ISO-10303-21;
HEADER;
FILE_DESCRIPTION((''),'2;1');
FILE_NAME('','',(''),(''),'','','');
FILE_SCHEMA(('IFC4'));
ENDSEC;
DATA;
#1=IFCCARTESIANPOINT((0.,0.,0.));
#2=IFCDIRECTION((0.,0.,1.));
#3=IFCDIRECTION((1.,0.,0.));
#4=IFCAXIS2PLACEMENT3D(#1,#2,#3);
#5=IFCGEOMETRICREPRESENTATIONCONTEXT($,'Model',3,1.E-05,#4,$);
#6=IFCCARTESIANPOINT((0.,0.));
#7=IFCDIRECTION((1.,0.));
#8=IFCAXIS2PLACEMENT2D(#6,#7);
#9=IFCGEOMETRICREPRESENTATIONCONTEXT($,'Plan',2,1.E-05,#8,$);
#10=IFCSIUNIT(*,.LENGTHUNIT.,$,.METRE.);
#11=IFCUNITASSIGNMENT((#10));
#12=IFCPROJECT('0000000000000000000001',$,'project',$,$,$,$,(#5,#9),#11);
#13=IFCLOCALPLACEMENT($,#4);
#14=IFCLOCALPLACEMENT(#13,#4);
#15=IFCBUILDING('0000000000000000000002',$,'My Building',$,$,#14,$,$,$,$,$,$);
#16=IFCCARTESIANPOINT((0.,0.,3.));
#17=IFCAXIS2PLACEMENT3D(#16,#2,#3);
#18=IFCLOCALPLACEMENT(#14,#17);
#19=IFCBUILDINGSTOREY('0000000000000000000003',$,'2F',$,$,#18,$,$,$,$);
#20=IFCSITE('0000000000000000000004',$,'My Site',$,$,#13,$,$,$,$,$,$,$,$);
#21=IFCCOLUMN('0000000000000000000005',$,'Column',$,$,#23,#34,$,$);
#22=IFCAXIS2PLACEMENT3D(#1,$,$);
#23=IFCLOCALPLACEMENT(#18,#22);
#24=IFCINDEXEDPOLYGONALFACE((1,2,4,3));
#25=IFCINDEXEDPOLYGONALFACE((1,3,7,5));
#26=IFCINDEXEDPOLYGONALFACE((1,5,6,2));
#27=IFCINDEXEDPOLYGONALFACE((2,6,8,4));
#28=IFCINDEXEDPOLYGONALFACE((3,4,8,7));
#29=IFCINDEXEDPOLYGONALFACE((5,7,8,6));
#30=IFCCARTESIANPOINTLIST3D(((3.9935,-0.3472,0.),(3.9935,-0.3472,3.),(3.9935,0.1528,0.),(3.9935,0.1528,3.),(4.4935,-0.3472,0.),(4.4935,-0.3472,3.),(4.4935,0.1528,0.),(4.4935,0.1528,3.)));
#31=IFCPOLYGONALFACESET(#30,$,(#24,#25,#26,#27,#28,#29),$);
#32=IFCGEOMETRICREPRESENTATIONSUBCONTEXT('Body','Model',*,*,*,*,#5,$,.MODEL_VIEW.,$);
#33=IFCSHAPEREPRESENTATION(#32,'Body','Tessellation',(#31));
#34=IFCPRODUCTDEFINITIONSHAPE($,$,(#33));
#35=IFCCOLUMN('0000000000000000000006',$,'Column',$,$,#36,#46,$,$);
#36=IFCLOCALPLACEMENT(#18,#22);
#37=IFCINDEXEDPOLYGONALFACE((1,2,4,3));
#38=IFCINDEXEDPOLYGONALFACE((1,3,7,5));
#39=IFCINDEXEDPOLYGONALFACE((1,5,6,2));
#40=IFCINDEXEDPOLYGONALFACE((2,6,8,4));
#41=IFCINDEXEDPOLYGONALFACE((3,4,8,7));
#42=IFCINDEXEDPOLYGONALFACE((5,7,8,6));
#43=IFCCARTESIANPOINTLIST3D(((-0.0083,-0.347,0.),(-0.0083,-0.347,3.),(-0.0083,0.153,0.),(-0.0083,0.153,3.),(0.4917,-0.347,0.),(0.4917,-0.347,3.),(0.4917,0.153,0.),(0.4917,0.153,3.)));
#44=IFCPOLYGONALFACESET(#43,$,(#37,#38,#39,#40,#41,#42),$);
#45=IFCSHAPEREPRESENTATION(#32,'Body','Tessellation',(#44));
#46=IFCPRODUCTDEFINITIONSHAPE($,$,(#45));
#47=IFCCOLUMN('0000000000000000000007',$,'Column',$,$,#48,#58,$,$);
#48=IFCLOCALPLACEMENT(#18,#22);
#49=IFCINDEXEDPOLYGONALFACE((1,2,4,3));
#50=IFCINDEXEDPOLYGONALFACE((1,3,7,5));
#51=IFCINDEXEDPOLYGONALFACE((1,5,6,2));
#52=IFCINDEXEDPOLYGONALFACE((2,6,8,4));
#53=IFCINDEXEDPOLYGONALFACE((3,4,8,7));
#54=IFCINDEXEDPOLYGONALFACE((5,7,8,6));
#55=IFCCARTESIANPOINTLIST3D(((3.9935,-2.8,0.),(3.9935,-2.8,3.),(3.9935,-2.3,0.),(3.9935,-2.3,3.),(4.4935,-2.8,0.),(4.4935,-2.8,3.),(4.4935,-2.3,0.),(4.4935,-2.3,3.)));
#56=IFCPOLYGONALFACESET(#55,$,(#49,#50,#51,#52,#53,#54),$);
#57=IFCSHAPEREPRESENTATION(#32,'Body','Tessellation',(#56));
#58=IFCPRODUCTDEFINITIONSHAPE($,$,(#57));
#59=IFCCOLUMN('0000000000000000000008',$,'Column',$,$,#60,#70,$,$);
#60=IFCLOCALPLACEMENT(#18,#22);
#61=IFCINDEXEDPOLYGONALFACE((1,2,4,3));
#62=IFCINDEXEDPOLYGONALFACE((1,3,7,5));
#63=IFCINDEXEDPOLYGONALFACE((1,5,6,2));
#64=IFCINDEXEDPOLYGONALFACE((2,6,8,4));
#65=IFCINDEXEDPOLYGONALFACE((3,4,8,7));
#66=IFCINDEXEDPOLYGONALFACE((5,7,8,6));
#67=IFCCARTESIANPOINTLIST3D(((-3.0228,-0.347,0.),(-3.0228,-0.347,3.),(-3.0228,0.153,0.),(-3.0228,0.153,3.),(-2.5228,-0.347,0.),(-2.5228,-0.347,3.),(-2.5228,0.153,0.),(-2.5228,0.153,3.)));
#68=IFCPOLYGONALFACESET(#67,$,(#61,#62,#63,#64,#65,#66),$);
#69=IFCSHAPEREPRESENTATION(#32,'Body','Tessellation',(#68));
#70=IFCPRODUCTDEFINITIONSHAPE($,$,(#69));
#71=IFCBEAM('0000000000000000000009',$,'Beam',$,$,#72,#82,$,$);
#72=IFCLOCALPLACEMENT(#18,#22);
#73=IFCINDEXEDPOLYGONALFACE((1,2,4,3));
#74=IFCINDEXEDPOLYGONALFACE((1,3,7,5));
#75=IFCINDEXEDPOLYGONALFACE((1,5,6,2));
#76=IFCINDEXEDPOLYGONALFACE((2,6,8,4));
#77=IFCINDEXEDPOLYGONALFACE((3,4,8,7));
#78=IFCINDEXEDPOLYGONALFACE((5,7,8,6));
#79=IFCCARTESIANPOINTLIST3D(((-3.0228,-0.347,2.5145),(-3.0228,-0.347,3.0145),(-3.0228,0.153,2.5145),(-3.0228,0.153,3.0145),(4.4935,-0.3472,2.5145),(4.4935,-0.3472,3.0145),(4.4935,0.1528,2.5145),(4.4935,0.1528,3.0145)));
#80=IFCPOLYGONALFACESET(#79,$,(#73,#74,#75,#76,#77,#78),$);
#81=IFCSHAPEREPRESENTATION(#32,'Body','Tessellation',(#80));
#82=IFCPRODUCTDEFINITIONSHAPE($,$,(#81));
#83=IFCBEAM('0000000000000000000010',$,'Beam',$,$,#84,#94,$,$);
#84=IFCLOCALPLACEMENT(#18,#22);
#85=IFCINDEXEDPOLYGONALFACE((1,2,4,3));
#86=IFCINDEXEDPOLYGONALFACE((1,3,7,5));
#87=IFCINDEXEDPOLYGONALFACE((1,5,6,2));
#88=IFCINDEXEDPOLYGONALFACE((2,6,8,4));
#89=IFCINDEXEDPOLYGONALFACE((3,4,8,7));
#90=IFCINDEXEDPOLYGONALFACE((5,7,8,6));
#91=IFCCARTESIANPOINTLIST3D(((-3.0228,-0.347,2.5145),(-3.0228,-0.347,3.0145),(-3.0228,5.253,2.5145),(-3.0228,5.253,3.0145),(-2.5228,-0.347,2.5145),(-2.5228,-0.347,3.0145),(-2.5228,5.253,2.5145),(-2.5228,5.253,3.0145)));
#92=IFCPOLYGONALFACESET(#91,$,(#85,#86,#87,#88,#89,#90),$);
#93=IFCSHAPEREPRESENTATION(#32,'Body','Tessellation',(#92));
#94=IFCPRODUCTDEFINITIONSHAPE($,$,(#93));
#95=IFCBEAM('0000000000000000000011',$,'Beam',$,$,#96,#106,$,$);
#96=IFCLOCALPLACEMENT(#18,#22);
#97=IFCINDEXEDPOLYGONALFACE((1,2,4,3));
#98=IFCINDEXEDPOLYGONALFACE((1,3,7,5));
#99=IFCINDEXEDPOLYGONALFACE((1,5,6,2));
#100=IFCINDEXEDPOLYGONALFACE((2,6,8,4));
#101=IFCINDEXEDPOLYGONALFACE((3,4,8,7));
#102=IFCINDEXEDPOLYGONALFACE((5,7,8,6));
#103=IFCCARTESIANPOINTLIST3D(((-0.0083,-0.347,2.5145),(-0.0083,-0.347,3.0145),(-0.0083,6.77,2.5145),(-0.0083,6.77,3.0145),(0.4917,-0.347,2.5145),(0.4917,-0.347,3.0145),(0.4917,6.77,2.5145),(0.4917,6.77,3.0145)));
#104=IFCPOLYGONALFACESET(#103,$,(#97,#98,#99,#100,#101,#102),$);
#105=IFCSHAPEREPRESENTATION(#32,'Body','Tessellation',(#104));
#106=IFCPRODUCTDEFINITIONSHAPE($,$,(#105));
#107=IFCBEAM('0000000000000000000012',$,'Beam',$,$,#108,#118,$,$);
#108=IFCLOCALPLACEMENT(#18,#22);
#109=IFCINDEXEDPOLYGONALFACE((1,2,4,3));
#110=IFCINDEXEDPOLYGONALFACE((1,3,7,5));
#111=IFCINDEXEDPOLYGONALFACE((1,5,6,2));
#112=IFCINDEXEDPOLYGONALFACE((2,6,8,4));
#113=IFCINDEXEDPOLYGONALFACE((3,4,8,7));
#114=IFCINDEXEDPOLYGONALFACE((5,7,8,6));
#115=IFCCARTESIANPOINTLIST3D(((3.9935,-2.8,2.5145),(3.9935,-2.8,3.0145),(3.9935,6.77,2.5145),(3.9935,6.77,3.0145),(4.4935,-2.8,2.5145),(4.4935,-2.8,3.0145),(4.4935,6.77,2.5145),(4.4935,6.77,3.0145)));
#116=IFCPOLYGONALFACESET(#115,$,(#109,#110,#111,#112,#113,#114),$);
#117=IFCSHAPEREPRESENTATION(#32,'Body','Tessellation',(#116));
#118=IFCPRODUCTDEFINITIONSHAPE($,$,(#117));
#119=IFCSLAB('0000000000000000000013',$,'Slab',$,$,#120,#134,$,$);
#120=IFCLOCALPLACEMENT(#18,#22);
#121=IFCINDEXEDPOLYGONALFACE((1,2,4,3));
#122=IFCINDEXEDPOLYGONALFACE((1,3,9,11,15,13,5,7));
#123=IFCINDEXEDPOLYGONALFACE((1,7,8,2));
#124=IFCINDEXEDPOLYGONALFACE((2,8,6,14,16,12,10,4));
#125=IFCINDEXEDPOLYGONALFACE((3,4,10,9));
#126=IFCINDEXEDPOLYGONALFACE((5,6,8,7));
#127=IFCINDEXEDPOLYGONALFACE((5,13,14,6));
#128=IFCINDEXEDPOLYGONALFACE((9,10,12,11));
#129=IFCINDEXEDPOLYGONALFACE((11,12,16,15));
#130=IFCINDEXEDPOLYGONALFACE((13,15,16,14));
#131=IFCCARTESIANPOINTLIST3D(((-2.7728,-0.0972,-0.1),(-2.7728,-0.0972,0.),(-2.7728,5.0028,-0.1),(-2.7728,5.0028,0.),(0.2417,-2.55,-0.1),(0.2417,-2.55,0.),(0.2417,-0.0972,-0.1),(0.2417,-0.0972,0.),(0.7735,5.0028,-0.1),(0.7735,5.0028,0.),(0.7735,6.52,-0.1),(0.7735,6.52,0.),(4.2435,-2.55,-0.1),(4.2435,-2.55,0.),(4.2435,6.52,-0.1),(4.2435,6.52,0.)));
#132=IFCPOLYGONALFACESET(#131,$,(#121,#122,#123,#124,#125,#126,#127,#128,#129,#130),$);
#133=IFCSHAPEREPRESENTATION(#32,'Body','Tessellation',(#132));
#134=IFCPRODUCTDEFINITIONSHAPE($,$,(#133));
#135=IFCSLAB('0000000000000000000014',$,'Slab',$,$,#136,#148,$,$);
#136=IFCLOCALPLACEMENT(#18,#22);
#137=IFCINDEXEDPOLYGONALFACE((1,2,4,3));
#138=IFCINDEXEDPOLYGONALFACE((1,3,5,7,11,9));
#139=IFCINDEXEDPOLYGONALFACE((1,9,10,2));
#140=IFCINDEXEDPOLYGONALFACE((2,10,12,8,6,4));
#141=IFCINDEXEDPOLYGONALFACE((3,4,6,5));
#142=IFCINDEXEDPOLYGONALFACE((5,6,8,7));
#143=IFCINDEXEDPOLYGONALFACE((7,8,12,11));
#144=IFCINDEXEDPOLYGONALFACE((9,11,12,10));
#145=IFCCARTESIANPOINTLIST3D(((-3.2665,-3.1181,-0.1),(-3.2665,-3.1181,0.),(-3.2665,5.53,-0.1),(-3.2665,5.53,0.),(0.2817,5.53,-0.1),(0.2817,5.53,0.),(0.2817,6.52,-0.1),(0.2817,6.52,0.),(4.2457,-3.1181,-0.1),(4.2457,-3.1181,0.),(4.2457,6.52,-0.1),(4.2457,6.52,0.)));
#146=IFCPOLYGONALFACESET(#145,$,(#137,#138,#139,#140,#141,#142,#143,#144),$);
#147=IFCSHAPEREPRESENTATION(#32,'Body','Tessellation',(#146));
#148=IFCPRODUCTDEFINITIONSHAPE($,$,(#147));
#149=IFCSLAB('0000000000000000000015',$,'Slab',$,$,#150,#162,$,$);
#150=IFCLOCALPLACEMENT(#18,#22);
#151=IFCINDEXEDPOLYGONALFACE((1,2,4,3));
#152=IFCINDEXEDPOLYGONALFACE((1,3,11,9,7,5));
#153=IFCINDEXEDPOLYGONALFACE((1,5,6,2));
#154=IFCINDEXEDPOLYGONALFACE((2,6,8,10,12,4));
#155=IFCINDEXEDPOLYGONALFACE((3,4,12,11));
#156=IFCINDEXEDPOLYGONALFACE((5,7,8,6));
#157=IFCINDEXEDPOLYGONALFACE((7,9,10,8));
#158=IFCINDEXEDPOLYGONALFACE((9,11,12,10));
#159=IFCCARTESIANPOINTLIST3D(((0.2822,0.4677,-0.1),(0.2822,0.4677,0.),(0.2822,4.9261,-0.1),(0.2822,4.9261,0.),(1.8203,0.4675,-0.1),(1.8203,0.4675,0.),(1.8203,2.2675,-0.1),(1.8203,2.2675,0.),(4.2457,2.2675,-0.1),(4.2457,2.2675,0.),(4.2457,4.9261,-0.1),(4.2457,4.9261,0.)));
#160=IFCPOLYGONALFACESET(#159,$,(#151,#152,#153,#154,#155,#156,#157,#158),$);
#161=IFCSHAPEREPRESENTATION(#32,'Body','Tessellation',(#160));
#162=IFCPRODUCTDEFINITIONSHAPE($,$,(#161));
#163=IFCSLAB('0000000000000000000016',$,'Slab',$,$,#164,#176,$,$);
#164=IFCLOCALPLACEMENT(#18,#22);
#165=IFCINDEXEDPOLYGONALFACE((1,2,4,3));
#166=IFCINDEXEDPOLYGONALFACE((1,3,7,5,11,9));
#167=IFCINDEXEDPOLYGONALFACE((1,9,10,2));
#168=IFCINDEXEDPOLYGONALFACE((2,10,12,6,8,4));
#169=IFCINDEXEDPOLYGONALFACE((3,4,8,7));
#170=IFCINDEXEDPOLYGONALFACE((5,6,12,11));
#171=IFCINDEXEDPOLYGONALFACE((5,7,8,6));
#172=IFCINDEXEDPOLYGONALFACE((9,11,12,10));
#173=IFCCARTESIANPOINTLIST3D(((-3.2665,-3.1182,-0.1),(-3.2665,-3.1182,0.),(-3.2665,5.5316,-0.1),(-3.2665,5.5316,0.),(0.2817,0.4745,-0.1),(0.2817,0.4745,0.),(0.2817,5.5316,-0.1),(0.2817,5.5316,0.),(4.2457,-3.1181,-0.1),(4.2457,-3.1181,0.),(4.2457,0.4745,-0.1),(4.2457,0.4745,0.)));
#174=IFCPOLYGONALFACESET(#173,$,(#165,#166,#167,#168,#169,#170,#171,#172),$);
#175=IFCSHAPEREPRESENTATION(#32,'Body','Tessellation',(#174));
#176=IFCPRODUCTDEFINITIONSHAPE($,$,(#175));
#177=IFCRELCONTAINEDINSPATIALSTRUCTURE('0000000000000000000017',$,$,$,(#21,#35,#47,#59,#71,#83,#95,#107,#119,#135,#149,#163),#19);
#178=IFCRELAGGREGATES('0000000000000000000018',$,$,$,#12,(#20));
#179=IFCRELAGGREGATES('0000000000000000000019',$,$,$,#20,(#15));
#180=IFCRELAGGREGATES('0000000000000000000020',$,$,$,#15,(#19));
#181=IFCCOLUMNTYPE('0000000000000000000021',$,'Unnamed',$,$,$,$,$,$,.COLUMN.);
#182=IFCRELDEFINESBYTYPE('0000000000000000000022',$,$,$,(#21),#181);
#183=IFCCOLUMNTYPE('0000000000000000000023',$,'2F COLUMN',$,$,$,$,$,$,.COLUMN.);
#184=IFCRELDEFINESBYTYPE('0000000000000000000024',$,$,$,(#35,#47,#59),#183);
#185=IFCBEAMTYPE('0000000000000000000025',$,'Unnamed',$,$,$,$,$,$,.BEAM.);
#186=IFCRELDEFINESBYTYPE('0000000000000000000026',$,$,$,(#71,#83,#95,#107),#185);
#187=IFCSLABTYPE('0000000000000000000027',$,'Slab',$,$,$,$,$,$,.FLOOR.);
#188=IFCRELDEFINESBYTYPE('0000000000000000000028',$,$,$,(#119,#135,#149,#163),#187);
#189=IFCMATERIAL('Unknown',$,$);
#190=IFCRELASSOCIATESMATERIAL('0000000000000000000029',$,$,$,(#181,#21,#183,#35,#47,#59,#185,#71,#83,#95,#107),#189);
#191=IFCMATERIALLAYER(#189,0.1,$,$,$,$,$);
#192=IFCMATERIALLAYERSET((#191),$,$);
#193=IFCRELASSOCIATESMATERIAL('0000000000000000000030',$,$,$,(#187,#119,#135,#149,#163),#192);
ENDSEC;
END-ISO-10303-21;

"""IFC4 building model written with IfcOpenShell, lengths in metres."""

from ifc_helpers import new_model, si_unit, frame, origin_with_axes, origin_2d_with_axis, place, context, subcontext, project, spatial, indexed_curve, rectangle, outline, extrude, material, layer, layer_set, layer_usage, material_profile, profile_set, profile_usage, type_object, element, save


model = new_model("IFC4")

# Units and contexts
model_context = context("Model", 3, precision=1e-05, world=origin_with_axes())
plan_context = context("Plan", 2, precision=1e-05, world=origin_2d_with_axis())
body_context_1 = subcontext(model_context, "Body", "Model", "MODEL_VIEW")
ifc_project = project(units=[si_unit("LENGTHUNIT", "METRE")], contexts=[model_context, plan_context])

# Site, building, storey
site_placement = place(None, origin_with_axes())
site = spatial("IfcSite", under=ifc_project, at=site_placement, Name="My Site")
building_placement = place(site_placement, origin_with_axes())
building = spatial("IfcBuilding", under=site, at=building_placement, Name="My Building")
storey_placement = place(building_placement, frame((0.0, 0.0, 3.0), z_axis=(0.0, 0.0, 1.0), x_axis=(1.0, 0.0, 0.0)))
storey = spatial("IfcBuildingStorey", under=building, at=storey_placement, Name="2F")

# Columns
ifc_material = material(Name="Unknown")
ifc_material_profile_1 = material_profile(ifc_material, rectangle(XDim=0.5, YDim=0.5))
ifc_profile_set_1 = profile_set([ifc_material_profile_1])
ifc_profile_usage_1 = profile_usage(ifc_profile_set_1, cardinal=7)
column_type_1 = type_object("IfcColumnType", Name="Unnamed", PredefinedType="COLUMN", material=ifc_profile_set_1)
column_1_placement = place(storey_placement, frame((4.4935, 0.1528, 0.0), z_axis=(0.0, 0.0, 1.0), x_axis=(1.0, 0.0, 0.0)))
element("IfcColumn", 1, at=column_1_placement, inside=storey, type_object=column_type_1, material=ifc_profile_usage_1, Name="Column", context=body_context_1, shape_type="SweptSolid", body=[
    extrude(rectangle(XDim=0.5, YDim=0.5), frame((-0.25, -0.25, 0.0), z_axis=(0.0, 0.0, 1.0), x_axis=(1.0, 0.0, 0.0)), (0.0, 0.0, 1.0), 3.0),
])
ifc_material_profile_2 = material_profile(ifc_material, rectangle(XDim=0.5, YDim=0.5))
ifc_profile_set_2 = profile_set([ifc_material_profile_2])
ifc_profile_usage_2 = profile_usage(ifc_profile_set_2, cardinal=7)
column_type_2 = type_object("IfcColumnType", Name="2F COLUMN", PredefinedType="COLUMN", material=ifc_profile_set_2)
column_2_placement = place(storey_placement, frame((0.4917, 0.153, 0.0), z_axis=(0.0, 0.0, 1.0), x_axis=(1.0, 0.0, 0.0)))
element("IfcColumn", 2, at=column_2_placement, inside=storey, type_object=column_type_2, material=ifc_profile_usage_2, Name="Column", context=body_context_1, shape_type="SweptSolid", body=[
    extrude(rectangle(XDim=0.5, YDim=0.5), frame((-0.25, -0.25, 0.0), z_axis=(0.0, 0.0, 1.0), x_axis=(1.0, 0.0, 0.0)), (0.0, 0.0, 1.0), 3.0),
])
ifc_profile_usage_3 = profile_usage(ifc_profile_set_2, cardinal=7)
column_3_placement = place(storey_placement, frame((4.4935, -2.3, 0.0), z_axis=(0.0, 0.0, 1.0), x_axis=(1.0, 0.0, 0.0)))
element("IfcColumn", 3, at=column_3_placement, inside=storey, type_object=column_type_2, material=ifc_profile_usage_3, Name="Column", context=body_context_1, shape_type="SweptSolid", body=[
    extrude(rectangle(XDim=0.5, YDim=0.5), frame((-0.25, -0.25, 0.0), z_axis=(0.0, 0.0, 1.0), x_axis=(1.0, 0.0, 0.0)), (0.0, 0.0, 1.0), 3.0),
])
ifc_profile_usage_4 = profile_usage(ifc_profile_set_2, cardinal=7)
column_4_placement = place(storey_placement, frame((-2.5228, 0.153, 0.0), z_axis=(0.0, 0.0, 1.0), x_axis=(1.0, 0.0, 0.0)))
element("IfcColumn", 4, at=column_4_placement, inside=storey, type_object=column_type_2, material=ifc_profile_usage_4, Name="Column", context=body_context_1, shape_type="SweptSolid", body=[
    extrude(rectangle(XDim=0.5, YDim=0.5), frame((-0.25, -0.25, 0.0), z_axis=(0.0, 0.0, 1.0), x_axis=(1.0, 0.0, 0.0)), (0.0, 0.0, 1.0), 3.0),
])

# Beams
ifc_material_profile_3 = material_profile(ifc_material, rectangle(XDim=0.5, YDim=0.5))
ifc_profile_set_3 = profile_set([ifc_material_profile_3])
ifc_profile_usage_5 = profile_usage(ifc_profile_set_3, cardinal=7)
beam_type = type_object("IfcBeamType", Name="Unnamed", PredefinedType="BEAM", material=ifc_profile_set_3)
beam_1_placement = place(storey_placement, frame((-3.0228, 0.153, 3.0145), z_axis=(1.0, -0.000025, 0.0), x_axis=(0.000025, 1.0, 0.0)))
element("IfcBeam", 5, at=beam_1_placement, inside=storey, type_object=beam_type, material=ifc_profile_usage_5, Name="Beam", context=body_context_1, shape_type="SweptSolid", body=[
    extrude(rectangle(XDim=0.5, YDim=0.5), frame((-0.25, -0.25, 0.0), z_axis=(0.0, 0.0, 1.0), x_axis=(1.0, 0.0, 0.0)), (0.0, 0.0, 1.0), 7.5163),
])
ifc_profile_usage_6 = profile_usage(ifc_profile_set_3, cardinal=7)
beam_2_placement = place(storey_placement, frame((-3.0228, -0.347, 3.0145), z_axis=(0.0, 1.0, 0.0), x_axis=(-1.0, 0.0, 0.0)))
element("IfcBeam", 6, at=beam_2_placement, inside=storey, type_object=beam_type, material=ifc_profile_usage_6, Name="Beam", context=body_context_1, shape_type="SweptSolid", body=[
    extrude(rectangle(XDim=0.5, YDim=0.5), frame((-0.25, -0.25, 0.0), z_axis=(0.0, 0.0, 1.0), x_axis=(1.0, 0.0, 0.0)), (0.0, 0.0, 1.0), 5.6),
])
ifc_profile_usage_7 = profile_usage(ifc_profile_set_3, cardinal=7)
beam_3_placement = place(storey_placement, frame((-0.0083, -0.347, 3.0145), z_axis=(0.0, 1.0, 0.0), x_axis=(-1.0, 0.0, 0.0)))
element("IfcBeam", 7, at=beam_3_placement, inside=storey, type_object=beam_type, material=ifc_profile_usage_7, Name="Beam", context=body_context_1, shape_type="SweptSolid", body=[
    extrude(rectangle(XDim=0.5, YDim=0.5), frame((-0.25, -0.25, 0.0), z_axis=(0.0, 0.0, 1.0), x_axis=(1.0, 0.0, 0.0)), (0.0, 0.0, 1.0), 7.117),
])
ifc_profile_usage_8 = profile_usage(ifc_profile_set_3, cardinal=7)
beam_4_placement = place(storey_placement, frame((3.9935, -2.8, 3.0145), z_axis=(0.0, 1.0, 0.0), x_axis=(-1.0, 0.0, 0.0)))
element("IfcBeam", 8, at=beam_4_placement, inside=storey, type_object=beam_type, material=ifc_profile_usage_8, Name="Beam", context=body_context_1, shape_type="SweptSolid", body=[
    extrude(rectangle(XDim=0.5, YDim=0.5), frame((-0.25, -0.25, 0.0), z_axis=(0.0, 0.0, 1.0), x_axis=(1.0, 0.0, 0.0)), (0.0, 0.0, 1.0), 9.57),
])

# Slabs
ifc_layer_1 = layer(ifc_material, 0.1)
ifc_layer_set_1 = layer_set([ifc_layer_1])
ifc_layer_usage_1 = layer_usage(ifc_layer_set_1, "AXIS3", "POSITIVE", -0.1)
slab_type = type_object("IfcSlabType", Name="Slab", PredefinedType="FLOOR", material=ifc_layer_set_1)
slab_1_placement = place(storey_placement, frame((4.2435, -2.55, 0.0), z_axis=(0.0, 0.0, 1.0), x_axis=(1.0, 0.0, 0.0)))
element("IfcSlab", 9, at=slab_1_placement, inside=storey, type_object=slab_type, material=ifc_layer_usage_1, Name="Slab", context=body_context_1, shape_type="SweptSolid", body=[
    extrude(outline(indexed_curve([(0.0, 0.0), (0.0, 9.07), (-3.47, 9.07), (-3.47, 7.5528), (-7.0163, 7.5528), (-7.0163, 2.4528), (-4.0018, 2.4528), (-4.0018, 0.0), (0.0, 0.0)])), frame((0.0, 0.0, -0.1), z_axis=(0.0, 0.0, 1.0), x_axis=(1.0, 0.0, 0.0)), (0.0, 0.0, 1.0), 0.1),
])
ifc_layer_usage_2 = layer_usage(ifc_layer_set_1, "AXIS3", "POSITIVE", -0.1)
slab_2_placement = place(storey_placement, frame((4.2457, -3.1181, 0.0), z_axis=(0.0, 0.0, 1.0), x_axis=(1.0, 0.0, 0.0)))
element("IfcSlab", 10, at=slab_2_placement, inside=storey, type_object=slab_type, material=ifc_layer_usage_2, Name="Slab", context=body_context_1, shape_type="SweptSolid", body=[
    extrude(outline(indexed_curve([(0.0, 0.0), (0.0, 9.6381), (-3.964, 9.6381), (-3.964, 8.6481), (-7.5122, 8.6481), (-7.5122, 0.0), (0.0, 0.0)])), frame((0.0, 0.0, -0.1), z_axis=(0.0, 0.0, 1.0), x_axis=(1.0, 0.0, 0.0)), (0.0, 0.0, 1.0), 0.1),
])
ifc_layer_usage_3 = layer_usage(ifc_layer_set_1, "AXIS3", "POSITIVE", -0.1)
slab_3_placement = place(storey_placement, frame((1.8203, 0.4675, 0.0), z_axis=(0.0, 0.0, 1.0), x_axis=(1.0, 0.0, 0.0)))
element("IfcSlab", 11, at=slab_3_placement, inside=storey, type_object=slab_type, material=ifc_layer_usage_3, Name="Slab", context=body_context_1, shape_type="SweptSolid", body=[
    extrude(outline(indexed_curve([(0.0, 0.0), (0.0, 1.8), (2.4254, 1.8), (2.4254, 4.4586), (-1.5381, 4.4586), (-1.5381, 0.0002), (0.0, 0.0)])), frame((0.0, 0.0, -0.1), z_axis=(0.0, 0.0, 1.0), x_axis=(1.0, 0.0, 0.0)), (0.0, 0.0, 1.0), 0.1),
])
ifc_layer_usage_4 = layer_usage(ifc_layer_set_1, "AXIS3", "POSITIVE", -0.1)
slab_4_placement = place(storey_placement, frame((4.2457, -3.1181, 0.0), z_axis=(0.0, 0.0, 1.0), x_axis=(1.0, 0.0, 0.0)))
element("IfcSlab", 12, at=slab_4_placement, inside=storey, type_object=slab_type, material=ifc_layer_usage_4, Name="Slab", context=body_context_1, shape_type="SweptSolid", body=[
    extrude(outline(indexed_curve([(0.0, 0.0), (0.0, 3.5926), (-3.964, 3.5926), (-3.964, 8.6496), (-7.5122, 8.6496), (-7.5122, -0.0001), (0.0, 0.0)])), frame((0.0, 0.0, -0.1), z_axis=(0.0, 0.0, 1.0), x_axis=(1.0, 0.0, 0.0)), (0.0, 0.0, 1.0), 0.1),
])

save(model, "model.ifc")
